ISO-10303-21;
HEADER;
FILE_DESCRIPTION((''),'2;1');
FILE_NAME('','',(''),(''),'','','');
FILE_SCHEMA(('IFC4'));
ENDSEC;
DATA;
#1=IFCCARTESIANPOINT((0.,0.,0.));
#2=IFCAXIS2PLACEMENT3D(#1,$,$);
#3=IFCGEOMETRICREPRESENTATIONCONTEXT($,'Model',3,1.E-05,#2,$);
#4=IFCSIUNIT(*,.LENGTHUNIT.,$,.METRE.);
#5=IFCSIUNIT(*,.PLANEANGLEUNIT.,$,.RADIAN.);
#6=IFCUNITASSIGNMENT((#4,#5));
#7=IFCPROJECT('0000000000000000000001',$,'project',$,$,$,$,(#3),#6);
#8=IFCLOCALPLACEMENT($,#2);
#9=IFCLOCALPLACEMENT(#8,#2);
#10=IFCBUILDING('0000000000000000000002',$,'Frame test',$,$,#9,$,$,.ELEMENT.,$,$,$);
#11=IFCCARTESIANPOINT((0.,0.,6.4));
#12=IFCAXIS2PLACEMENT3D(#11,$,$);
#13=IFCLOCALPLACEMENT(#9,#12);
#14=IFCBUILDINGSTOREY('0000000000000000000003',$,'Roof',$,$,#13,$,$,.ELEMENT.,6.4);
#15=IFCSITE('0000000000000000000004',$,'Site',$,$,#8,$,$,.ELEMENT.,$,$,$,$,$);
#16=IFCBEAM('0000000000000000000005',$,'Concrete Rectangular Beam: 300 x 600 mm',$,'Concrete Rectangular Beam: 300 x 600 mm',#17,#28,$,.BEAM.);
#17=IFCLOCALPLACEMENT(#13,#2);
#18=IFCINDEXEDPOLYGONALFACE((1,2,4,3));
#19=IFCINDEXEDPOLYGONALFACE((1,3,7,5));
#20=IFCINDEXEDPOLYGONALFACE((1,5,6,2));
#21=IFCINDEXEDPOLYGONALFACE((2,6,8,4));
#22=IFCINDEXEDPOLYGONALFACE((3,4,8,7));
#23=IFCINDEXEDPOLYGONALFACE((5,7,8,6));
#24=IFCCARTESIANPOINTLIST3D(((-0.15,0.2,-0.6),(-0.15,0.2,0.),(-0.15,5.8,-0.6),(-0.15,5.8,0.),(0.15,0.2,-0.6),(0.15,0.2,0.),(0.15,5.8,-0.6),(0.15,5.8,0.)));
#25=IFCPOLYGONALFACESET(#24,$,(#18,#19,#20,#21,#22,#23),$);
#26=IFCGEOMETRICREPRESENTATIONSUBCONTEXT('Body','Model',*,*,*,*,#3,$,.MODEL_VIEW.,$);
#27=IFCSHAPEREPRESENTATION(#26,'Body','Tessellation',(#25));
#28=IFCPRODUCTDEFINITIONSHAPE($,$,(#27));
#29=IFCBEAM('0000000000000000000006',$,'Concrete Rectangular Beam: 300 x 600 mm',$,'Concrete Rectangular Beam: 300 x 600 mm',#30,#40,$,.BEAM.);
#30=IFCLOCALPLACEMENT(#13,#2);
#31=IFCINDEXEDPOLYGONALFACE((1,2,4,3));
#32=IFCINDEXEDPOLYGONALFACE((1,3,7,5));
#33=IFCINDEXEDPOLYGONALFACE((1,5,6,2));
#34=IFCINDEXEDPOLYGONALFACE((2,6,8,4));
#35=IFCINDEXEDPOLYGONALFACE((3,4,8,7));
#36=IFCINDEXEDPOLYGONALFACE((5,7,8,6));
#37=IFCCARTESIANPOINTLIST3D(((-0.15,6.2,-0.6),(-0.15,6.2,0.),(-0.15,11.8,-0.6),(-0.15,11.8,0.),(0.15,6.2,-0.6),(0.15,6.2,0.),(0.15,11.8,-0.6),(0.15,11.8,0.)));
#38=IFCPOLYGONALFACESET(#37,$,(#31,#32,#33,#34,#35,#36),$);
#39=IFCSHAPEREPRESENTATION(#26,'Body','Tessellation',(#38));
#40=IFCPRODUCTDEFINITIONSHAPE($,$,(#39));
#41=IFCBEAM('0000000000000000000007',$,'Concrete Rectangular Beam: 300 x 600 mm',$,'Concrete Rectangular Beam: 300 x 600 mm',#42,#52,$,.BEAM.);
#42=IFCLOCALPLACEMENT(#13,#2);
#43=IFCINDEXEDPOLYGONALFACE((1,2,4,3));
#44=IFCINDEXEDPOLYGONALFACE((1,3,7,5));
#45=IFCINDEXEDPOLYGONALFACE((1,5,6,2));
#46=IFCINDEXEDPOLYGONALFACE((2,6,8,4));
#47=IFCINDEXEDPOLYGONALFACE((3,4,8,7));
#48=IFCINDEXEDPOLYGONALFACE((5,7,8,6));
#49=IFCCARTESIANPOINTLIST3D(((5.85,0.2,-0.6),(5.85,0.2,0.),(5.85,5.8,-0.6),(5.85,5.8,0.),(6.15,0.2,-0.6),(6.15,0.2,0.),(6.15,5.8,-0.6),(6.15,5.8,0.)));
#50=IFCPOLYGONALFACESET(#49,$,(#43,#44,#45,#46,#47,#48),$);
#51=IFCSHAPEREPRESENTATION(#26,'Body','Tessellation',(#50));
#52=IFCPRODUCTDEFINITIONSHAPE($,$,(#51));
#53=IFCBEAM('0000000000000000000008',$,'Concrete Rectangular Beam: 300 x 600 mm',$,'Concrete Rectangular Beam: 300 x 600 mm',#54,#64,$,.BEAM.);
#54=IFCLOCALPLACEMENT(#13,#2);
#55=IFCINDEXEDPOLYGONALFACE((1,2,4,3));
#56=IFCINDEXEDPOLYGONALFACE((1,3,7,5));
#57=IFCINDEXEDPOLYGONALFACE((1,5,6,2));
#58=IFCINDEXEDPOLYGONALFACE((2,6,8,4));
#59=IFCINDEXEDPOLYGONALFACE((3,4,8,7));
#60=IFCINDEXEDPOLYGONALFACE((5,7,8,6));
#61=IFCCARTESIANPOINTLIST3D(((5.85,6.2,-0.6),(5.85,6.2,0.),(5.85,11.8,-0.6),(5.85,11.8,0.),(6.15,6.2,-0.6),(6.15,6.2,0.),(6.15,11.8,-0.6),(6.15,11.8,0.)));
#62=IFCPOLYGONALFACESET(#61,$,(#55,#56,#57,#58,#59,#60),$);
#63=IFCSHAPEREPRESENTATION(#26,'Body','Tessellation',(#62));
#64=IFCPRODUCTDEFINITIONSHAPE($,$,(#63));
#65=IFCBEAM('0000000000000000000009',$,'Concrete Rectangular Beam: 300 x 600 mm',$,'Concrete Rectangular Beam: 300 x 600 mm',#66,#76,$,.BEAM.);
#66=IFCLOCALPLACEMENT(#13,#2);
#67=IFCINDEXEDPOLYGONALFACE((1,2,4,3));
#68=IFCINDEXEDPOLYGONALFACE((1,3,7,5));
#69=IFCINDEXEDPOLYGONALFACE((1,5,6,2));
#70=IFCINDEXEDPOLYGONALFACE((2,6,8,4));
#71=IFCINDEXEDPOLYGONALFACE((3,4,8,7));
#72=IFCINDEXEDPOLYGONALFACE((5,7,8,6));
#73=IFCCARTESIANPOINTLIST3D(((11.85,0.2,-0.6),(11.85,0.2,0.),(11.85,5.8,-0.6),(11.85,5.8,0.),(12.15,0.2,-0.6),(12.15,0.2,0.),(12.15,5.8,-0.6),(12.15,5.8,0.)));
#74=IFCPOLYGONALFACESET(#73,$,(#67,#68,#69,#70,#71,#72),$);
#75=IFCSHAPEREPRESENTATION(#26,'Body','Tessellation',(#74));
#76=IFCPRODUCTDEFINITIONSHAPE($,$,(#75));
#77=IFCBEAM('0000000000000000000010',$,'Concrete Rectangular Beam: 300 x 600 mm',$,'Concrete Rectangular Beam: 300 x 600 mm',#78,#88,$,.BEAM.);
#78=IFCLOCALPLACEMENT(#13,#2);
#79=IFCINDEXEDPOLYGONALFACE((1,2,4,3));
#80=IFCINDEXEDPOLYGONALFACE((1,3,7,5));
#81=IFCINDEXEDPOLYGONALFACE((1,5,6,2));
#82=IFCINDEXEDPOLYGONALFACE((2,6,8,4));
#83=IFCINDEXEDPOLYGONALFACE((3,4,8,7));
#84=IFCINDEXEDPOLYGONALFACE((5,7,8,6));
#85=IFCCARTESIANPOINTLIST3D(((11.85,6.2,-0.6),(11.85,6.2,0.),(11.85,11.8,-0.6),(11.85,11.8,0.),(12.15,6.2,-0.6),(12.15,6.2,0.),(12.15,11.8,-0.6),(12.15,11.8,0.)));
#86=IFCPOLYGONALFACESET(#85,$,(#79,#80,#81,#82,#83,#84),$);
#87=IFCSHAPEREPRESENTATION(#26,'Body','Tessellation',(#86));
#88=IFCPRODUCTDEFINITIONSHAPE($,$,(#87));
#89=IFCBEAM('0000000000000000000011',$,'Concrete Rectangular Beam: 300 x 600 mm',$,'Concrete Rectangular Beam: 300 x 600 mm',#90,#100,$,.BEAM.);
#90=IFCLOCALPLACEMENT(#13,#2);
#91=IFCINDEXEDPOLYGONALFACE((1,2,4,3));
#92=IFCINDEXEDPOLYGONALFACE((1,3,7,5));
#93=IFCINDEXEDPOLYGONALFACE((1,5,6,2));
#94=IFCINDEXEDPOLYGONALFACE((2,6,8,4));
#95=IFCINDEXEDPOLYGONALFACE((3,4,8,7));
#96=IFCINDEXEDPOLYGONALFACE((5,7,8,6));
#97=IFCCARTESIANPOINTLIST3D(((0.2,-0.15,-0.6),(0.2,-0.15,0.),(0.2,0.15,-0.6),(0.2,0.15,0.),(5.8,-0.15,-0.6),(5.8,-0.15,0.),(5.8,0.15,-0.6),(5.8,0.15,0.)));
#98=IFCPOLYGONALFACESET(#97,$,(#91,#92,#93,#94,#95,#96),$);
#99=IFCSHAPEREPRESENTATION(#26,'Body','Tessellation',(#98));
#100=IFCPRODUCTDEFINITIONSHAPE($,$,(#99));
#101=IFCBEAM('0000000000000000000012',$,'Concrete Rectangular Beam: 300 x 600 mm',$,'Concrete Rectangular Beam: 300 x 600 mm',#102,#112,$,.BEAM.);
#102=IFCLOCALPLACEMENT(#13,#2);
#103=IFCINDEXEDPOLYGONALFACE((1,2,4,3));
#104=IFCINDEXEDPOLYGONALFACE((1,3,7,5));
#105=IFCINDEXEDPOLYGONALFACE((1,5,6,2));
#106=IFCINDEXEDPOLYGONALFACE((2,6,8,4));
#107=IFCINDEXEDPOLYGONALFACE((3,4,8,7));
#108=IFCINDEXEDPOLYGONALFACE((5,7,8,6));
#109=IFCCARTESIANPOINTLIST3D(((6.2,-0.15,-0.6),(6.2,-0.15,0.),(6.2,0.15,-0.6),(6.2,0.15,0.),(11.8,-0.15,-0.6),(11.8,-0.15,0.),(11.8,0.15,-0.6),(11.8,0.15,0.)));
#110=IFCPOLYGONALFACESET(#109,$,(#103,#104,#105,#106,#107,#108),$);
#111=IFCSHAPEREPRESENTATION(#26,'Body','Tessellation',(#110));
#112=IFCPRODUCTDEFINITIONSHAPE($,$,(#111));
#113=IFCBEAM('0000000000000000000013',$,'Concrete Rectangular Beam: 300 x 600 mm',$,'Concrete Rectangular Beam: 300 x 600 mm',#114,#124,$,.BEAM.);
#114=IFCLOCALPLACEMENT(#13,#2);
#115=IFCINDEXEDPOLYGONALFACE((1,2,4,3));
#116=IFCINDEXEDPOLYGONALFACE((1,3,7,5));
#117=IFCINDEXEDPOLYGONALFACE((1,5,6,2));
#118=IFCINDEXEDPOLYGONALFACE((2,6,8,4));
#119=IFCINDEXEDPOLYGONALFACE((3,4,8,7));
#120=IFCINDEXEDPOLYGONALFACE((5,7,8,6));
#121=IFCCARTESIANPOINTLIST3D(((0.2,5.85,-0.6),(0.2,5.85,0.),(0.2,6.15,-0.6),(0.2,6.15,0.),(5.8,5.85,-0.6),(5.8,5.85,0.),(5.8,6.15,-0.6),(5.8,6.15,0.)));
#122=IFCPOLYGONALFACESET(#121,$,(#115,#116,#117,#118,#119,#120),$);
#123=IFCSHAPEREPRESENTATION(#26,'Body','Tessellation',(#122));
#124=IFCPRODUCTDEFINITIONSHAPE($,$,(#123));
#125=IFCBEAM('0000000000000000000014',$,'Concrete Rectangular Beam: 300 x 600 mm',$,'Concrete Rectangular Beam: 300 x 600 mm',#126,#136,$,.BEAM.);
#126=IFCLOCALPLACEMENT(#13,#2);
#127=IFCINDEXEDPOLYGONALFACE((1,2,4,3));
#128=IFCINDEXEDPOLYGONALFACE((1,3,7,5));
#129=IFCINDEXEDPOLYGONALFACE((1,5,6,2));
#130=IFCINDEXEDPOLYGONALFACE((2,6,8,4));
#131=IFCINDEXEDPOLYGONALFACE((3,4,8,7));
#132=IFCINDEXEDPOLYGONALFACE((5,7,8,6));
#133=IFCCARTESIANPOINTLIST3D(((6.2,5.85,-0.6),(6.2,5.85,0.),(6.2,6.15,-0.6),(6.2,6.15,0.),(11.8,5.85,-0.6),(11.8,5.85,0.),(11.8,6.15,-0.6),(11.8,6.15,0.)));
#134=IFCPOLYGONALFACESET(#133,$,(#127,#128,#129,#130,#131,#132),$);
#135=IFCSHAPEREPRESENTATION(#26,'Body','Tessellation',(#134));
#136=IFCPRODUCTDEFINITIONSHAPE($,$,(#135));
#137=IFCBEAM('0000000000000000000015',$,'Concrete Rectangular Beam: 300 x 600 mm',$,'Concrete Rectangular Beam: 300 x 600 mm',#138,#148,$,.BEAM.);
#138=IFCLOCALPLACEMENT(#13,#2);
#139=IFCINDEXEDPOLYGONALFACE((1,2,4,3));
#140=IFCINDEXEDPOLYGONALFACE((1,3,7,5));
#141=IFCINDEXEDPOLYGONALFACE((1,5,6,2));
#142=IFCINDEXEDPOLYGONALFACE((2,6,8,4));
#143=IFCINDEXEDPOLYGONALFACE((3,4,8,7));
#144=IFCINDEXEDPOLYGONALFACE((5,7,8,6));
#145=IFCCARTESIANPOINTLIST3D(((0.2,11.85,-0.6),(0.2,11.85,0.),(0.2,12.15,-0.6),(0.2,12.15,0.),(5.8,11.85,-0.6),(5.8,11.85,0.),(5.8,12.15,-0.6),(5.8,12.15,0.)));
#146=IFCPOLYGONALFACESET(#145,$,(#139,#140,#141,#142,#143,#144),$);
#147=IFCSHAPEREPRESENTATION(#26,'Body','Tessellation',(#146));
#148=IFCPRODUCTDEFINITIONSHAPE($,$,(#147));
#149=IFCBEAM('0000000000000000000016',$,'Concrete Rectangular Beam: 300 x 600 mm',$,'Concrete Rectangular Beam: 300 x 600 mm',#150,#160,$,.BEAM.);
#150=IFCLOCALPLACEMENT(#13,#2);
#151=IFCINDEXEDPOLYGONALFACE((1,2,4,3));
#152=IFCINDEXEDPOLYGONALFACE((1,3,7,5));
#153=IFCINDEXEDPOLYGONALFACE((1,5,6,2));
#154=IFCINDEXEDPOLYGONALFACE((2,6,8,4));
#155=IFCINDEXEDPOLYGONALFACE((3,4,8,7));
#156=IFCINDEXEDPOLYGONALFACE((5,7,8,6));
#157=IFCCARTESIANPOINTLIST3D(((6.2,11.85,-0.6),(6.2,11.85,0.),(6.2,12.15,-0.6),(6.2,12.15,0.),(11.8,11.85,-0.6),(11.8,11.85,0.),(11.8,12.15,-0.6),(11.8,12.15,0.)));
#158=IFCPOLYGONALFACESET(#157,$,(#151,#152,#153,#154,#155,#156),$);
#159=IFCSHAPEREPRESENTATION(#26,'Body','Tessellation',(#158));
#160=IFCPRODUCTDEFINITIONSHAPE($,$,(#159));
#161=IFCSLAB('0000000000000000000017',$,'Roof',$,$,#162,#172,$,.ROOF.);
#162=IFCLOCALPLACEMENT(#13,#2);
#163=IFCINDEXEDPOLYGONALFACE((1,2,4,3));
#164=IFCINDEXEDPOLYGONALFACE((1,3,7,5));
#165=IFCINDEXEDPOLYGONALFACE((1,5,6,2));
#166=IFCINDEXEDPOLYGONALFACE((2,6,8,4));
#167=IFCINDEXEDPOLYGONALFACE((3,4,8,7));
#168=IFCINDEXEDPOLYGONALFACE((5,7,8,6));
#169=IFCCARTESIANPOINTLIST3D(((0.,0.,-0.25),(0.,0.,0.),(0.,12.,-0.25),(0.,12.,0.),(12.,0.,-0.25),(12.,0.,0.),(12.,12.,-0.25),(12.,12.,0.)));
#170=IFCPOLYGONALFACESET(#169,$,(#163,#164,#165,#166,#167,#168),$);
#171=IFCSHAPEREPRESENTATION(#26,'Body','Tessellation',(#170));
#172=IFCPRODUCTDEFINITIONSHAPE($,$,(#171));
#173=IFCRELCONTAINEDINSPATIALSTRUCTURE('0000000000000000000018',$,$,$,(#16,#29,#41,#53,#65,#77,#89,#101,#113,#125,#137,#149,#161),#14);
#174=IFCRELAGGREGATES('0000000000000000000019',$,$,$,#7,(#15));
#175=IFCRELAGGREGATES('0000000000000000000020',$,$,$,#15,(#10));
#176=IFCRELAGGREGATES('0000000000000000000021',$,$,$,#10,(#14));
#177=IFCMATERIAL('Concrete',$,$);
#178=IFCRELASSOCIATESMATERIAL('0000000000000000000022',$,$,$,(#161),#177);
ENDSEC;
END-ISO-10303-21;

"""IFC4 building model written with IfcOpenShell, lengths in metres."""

from ifc_helpers import new_model, si_unit, frame, origin, place, context, subcontext, project, spatial, polyline, outline, extrude, material, element, save


model = new_model("IFC4")

# Units and contexts
model_context = context("Model", 3, precision=1e-05, world=origin())
body_context = subcontext(model_context, "Body", "Model", "MODEL_VIEW")
ifc_project = project(units=[si_unit("LENGTHUNIT", "METRE"), si_unit("PLANEANGLEUNIT", "RADIAN")], contexts=[model_context])

# Site, building, storey
site_placement = place(None, origin())
site = spatial("IfcSite", under=ifc_project, at=site_placement, Name="Site", CompositionType="ELEMENT")
building_placement = place(site_placement, origin())
building = spatial("IfcBuilding", under=site, at=building_placement, Name="Frame test", CompositionType="ELEMENT")
storey_placement = place(building_placement, frame((0.0, 0.0, 6.4)))
storey = spatial("IfcBuildingStorey", under=building, at=storey_placement, Name="Roof", CompositionType="ELEMENT", Elevation=6.4)

# Beams
for number, where, z_axis, x_axis, name in (
    (1, (0.0, 0.2, -0.3), (0.0, 1.0, 0.0), (-1.0, 0.0, 0.0), "Concrete Rectangular Beam: 300 x 600 mm"),
    (2, (0.0, 6.2, -0.3), (0.0, 1.0, 0.0), (-1.0, 0.0, 0.0), "Concrete Rectangular Beam: 300 x 600 mm"),
    (3, (6.0, 0.2, -0.3), (0.0, 1.0, 0.0), (-1.0, 0.0, 0.0), "Concrete Rectangular Beam: 300 x 600 mm"),
    (4, (6.0, 6.2, -0.3), (0.0, 1.0, 0.0), (-1.0, 0.0, 0.0), "Concrete Rectangular Beam: 300 x 600 mm"),
    (5, (12.0, 0.2, -0.3), (0.0, 1.0, 0.0), (-1.0, 0.0, 0.0), "Concrete Rectangular Beam: 300 x 600 mm"),
    (6, (12.0, 6.2, -0.3), (0.0, 1.0, 0.0), (-1.0, 0.0, 0.0), "Concrete Rectangular Beam: 300 x 600 mm"),
    (7, (0.2, 0.0, -0.3), (1.0, 0.0, 0.0), (0.0, 1.0, 0.0), "Concrete Rectangular Beam: 300 x 600 mm"),
    (8, (6.2, 0.0, -0.3), (1.0, 0.0, 0.0), (0.0, 1.0, 0.0), "Concrete Rectangular Beam: 300 x 600 mm"),
    (9, (0.2, 6.0, -0.3), (1.0, 0.0, 0.0), (0.0, 1.0, 0.0), "Concrete Rectangular Beam: 300 x 600 mm"),
    (10, (6.2, 6.0, -0.3), (1.0, 0.0, 0.0), (0.0, 1.0, 0.0), "Concrete Rectangular Beam: 300 x 600 mm"),
    (11, (0.2, 12.0, -0.3), (1.0, 0.0, 0.0), (0.0, 1.0, 0.0), "Concrete Rectangular Beam: 300 x 600 mm"),
    (12, (6.2, 12.0, -0.3), (1.0, 0.0, 0.0), (0.0, 1.0, 0.0), "Concrete Rectangular Beam: 300 x 600 mm"),
):
    element("IfcBeam", number, at=place(storey_placement, frame(where, z_axis=z_axis, x_axis=x_axis)), inside=storey, Name=name, ObjectType="Concrete Rectangular Beam: 300 x 600 mm", PredefinedType="BEAM", context=body_context, shape_type="SweptSolid", body=[
        extrude(outline(polyline([(-0.15, -0.3), (0.15, -0.3), (0.15, 0.3), (-0.15, 0.3), (-0.15, -0.3)])), origin(), (0.0, 0.0, 1.0), 5.6),
    ])

# Slab
ifc_material = material(Name="Concrete")
slab_placement = place(storey_placement, frame((0.0, 0.0, -0.25)))
element("IfcSlab", 13, at=slab_placement, inside=storey, material=ifc_material, Name="Roof", PredefinedType="ROOF", context=body_context, shape_type="SweptSolid", body=[
    extrude(outline(polyline([(0.0, 0.0), (12.0, 0.0), (12.0, 12.0), (0.0, 12.0), (0.0, 0.0)])), origin(), (0.0, 0.0, 1.0), 0.25),
])

save(model, "model.ifc")
